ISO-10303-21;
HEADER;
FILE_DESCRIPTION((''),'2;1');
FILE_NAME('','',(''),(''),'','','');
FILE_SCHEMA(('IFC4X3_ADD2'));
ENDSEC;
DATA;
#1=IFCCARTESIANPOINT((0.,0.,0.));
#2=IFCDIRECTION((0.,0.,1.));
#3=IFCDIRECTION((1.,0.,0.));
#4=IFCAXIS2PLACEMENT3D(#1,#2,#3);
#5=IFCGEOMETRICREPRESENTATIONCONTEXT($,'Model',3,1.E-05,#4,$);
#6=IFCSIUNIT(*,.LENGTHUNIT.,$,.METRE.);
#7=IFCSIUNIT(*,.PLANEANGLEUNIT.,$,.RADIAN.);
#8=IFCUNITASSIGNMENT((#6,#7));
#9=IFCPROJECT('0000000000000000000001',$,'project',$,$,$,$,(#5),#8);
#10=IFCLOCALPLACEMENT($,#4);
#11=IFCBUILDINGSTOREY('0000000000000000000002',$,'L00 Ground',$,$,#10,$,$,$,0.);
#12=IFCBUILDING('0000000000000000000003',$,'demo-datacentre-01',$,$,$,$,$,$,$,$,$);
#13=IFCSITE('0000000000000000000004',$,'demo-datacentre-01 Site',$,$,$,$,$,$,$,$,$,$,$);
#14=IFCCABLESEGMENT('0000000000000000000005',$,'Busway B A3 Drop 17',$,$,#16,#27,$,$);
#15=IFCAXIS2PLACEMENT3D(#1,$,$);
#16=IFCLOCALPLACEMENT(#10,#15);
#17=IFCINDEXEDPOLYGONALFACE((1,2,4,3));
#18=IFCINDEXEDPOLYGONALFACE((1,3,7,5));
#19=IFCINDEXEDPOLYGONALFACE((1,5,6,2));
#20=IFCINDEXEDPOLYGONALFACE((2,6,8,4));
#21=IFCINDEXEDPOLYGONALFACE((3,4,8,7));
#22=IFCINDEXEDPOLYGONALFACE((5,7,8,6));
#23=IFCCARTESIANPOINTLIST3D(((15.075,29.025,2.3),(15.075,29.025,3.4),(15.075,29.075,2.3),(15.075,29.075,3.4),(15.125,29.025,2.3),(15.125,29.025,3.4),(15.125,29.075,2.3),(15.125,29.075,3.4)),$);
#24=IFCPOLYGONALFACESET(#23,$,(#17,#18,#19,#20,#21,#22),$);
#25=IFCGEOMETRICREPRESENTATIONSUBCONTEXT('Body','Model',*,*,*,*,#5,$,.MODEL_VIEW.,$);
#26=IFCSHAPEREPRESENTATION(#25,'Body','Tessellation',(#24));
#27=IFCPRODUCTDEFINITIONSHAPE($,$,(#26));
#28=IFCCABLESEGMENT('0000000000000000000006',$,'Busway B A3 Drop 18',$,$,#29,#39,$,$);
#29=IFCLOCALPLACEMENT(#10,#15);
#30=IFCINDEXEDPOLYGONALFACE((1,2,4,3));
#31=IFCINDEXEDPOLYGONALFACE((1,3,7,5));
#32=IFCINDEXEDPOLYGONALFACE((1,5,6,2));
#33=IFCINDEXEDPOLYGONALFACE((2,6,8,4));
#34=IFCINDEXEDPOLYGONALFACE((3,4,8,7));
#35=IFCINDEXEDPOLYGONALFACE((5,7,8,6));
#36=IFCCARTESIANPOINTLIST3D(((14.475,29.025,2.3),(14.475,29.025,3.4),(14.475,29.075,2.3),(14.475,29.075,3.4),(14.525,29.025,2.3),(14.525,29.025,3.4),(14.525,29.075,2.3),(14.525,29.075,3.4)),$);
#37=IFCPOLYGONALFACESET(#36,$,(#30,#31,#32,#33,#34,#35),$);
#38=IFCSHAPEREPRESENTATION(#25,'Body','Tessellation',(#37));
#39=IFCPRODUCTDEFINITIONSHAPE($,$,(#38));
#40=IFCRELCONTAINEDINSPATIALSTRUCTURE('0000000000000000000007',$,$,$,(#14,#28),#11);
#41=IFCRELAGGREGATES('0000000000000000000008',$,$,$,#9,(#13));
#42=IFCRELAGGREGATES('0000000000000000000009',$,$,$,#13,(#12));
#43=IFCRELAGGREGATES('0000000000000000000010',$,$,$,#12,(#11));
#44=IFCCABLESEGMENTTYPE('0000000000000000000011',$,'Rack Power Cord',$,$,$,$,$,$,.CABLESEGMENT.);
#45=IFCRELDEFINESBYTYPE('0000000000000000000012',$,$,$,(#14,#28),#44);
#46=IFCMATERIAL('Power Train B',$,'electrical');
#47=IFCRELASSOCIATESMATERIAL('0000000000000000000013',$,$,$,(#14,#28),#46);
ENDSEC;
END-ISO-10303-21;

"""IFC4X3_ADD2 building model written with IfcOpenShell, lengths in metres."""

from ifc_helpers import new_model, si_unit, frame, origin_with_axes, place, context, subcontext, project, spatial, rectangle, extrude, material, type_object, element, save


model = new_model("IFC4X3_ADD2")

# Units and contexts
model_context = context("Model", 3, precision=1e-05, world=origin_with_axes())
body_context = subcontext(model_context, "Body", "Model", "MODEL_VIEW")
ifc_project = project(units=[si_unit("LENGTHUNIT", "METRE"), si_unit("PLANEANGLEUNIT", "RADIAN")], contexts=[model_context])

# Site, building, storey
site = spatial("IfcSite", under=ifc_project, Name="demo-datacentre-01 Site")
building = spatial("IfcBuilding", under=site, Name="demo-datacentre-01")
storey_placement = place(None, origin_with_axes())
storey = spatial("IfcBuildingStorey", under=building, at=storey_placement, Name="L00 Ground", Elevation=0.0)

# Shared definitions
ifc_material_1 = material(Name="Power Train B", Category="electrical")

# Cable segments
cable_segment_type_1 = type_object("IfcCableSegmentType", Name="Rack Power Cord", PredefinedType="CABLESEGMENT")
for number, where, z_axis, x_axis, name in (
    (1, (15.1, 29.05, 3.4), (0.0, 0.0, -1.0), (1.0, 0.0, 0.0), "Busway B A3 Drop 17"),
    (2, (14.5, 29.05, 3.4), (0.0, 0.0, -1.0), (1.0, 0.0, 0.0), "Busway B A3 Drop 18"),
):
    element("IfcCableSegment", number, at=place(storey_placement, frame(where, z_axis=z_axis, x_axis=x_axis)), inside=storey, type_object=cable_segment_type_1, material=ifc_material_1, Name=name, context=body_context, shape_type="SweptSolid", body=[
        extrude(rectangle(XDim=0.05, YDim=0.05), origin_with_axes(), (0.0, 0.0, 1.0), 1.1),
    ])

save(model, "model.ifc")
